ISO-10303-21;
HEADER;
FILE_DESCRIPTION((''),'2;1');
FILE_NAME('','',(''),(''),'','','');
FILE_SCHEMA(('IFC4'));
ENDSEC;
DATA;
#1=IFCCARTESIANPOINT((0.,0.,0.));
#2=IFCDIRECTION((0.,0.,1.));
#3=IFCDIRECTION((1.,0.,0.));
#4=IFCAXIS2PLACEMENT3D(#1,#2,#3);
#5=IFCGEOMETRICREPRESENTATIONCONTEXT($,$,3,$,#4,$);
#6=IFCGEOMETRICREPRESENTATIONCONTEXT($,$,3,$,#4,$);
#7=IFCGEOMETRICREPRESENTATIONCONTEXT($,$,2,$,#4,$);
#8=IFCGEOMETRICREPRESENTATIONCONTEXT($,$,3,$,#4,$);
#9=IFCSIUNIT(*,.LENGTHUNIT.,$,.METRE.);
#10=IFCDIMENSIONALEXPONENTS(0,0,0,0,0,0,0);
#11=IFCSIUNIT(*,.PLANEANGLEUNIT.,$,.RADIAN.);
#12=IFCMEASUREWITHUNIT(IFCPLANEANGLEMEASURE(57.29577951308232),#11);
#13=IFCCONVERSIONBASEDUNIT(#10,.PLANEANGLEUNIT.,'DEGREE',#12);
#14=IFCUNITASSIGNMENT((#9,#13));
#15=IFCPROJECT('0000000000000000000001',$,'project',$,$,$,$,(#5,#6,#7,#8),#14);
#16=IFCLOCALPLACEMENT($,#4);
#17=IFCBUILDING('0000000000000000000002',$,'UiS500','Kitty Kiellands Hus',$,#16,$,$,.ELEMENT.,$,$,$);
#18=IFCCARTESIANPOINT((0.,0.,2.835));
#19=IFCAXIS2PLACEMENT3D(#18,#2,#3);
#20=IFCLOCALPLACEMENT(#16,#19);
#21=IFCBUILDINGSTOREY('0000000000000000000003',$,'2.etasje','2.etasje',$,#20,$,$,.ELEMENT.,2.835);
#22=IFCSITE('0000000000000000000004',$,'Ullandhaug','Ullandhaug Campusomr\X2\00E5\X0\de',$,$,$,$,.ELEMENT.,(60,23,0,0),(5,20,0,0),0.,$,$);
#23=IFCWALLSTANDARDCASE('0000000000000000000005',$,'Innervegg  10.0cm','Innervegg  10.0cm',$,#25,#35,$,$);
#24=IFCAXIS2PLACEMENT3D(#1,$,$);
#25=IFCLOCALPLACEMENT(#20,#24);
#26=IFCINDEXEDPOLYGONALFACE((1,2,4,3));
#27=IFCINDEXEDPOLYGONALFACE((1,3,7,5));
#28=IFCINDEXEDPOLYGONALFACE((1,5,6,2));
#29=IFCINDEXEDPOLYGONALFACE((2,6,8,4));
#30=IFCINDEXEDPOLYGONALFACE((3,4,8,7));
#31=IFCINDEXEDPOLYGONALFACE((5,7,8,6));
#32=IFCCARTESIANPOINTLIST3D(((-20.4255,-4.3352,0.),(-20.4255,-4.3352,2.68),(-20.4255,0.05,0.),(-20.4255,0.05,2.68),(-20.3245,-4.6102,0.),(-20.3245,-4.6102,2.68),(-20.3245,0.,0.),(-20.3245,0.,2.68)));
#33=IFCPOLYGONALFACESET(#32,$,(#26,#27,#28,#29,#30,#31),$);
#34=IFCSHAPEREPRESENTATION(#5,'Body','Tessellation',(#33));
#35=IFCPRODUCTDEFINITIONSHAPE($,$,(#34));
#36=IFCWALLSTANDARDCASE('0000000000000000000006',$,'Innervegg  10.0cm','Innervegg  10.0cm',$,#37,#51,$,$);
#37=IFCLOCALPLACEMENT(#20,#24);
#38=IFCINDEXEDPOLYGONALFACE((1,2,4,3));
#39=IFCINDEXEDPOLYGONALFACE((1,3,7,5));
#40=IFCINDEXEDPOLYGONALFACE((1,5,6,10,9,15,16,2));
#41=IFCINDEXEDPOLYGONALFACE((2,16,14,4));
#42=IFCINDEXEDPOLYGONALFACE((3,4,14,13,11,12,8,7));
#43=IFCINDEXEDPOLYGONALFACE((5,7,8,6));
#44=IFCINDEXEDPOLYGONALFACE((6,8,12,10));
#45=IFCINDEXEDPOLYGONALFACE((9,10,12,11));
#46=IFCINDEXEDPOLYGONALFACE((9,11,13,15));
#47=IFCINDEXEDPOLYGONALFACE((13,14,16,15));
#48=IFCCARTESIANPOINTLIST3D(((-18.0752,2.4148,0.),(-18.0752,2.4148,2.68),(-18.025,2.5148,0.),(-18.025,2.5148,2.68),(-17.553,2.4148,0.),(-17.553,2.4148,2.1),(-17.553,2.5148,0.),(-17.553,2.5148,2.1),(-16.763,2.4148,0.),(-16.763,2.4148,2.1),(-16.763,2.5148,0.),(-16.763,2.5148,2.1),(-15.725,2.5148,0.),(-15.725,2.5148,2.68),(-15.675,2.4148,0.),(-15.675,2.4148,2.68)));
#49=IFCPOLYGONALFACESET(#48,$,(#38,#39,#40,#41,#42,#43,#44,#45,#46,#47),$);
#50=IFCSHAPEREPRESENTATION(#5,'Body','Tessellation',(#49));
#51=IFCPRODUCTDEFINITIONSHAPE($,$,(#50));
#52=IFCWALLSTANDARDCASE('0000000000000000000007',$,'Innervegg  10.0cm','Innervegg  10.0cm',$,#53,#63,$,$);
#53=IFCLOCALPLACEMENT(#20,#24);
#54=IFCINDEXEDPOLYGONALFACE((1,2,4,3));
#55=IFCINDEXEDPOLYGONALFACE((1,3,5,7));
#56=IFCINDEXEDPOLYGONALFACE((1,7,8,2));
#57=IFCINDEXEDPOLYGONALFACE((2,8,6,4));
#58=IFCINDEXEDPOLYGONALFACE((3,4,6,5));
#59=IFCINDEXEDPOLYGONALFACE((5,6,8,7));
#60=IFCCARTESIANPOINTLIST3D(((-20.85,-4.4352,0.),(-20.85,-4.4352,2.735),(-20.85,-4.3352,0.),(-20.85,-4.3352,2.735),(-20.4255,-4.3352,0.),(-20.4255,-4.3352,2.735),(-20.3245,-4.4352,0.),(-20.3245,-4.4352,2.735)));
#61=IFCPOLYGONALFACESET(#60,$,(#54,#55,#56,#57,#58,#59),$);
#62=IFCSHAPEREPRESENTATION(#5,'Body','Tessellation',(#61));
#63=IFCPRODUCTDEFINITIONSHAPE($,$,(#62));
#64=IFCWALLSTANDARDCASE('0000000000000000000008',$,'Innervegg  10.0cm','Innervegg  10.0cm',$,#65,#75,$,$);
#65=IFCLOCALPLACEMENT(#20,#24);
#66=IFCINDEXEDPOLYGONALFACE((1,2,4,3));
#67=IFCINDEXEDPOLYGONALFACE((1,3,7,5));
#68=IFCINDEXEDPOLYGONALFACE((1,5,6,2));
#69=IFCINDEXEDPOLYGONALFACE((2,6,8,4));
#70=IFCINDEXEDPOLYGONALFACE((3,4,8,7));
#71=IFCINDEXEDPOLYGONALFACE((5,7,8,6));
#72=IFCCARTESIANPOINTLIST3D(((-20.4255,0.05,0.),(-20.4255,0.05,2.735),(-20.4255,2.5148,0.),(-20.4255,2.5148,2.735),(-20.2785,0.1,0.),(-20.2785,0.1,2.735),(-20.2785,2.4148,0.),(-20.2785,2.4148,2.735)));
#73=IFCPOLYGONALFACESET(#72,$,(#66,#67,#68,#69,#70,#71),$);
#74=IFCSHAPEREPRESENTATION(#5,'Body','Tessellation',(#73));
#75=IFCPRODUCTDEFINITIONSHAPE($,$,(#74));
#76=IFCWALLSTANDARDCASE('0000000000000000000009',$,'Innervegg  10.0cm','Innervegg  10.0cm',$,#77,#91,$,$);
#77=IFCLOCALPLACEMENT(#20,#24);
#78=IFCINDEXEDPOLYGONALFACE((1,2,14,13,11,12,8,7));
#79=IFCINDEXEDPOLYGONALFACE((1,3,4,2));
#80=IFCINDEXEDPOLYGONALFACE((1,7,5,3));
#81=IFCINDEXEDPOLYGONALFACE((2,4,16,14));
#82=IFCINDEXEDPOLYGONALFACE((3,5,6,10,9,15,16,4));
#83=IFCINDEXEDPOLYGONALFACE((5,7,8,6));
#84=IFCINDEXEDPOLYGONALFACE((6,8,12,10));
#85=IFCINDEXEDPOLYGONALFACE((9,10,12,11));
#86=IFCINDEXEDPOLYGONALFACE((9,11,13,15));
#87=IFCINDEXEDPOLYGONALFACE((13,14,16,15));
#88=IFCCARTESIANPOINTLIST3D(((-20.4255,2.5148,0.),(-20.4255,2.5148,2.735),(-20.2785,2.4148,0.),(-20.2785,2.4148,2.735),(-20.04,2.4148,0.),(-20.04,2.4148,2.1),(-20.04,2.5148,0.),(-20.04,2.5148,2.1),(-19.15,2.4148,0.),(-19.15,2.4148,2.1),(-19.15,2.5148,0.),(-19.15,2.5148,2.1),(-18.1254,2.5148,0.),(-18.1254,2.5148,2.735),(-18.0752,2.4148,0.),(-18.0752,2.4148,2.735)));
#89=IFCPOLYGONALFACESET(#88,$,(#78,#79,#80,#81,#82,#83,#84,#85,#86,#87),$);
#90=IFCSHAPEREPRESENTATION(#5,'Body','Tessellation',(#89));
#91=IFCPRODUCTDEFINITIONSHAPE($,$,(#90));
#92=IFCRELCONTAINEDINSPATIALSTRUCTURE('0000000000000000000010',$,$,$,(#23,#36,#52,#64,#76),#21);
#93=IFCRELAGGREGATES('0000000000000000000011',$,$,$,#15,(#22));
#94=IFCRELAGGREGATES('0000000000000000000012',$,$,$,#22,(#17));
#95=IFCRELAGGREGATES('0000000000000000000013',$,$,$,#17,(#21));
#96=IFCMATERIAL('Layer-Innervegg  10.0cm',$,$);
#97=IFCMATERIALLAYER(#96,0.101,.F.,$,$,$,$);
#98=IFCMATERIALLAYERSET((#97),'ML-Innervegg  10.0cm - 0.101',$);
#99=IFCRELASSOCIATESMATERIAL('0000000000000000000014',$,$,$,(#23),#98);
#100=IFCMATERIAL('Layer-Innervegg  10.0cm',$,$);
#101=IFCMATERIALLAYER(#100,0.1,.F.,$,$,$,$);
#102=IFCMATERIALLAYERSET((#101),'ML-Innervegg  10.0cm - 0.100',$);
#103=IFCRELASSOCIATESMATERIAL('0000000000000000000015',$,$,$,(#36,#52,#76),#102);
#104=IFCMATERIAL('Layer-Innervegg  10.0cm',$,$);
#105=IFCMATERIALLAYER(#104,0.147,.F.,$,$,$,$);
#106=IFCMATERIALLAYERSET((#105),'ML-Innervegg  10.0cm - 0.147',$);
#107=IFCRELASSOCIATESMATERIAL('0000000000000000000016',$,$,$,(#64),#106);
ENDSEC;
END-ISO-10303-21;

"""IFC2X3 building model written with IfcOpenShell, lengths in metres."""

from ifc_helpers import new_model, entity, si_unit, converted_unit, frame, origin_with_axes, place, context, project, spatial, polyline, outline, extrude, material, layer, layer_set, layer_usage, element, save


model = new_model("IFC2X3")

# Units and contexts
context_of_model_1 = context(None, 3, world=origin_with_axes())
context_of_model_2 = context(None, 3, world=origin_with_axes())
context_of_model_3 = context(None, 2, world=origin_with_axes())
context_of_model_4 = context(None, 3, world=origin_with_axes())
ifc_project = project(units=[si_unit("LENGTHUNIT", "METRE"), converted_unit("PLANEANGLEUNIT", "DEGREE", entity("IfcPlaneAngleMeasure", 57.29577951308232), si_unit("PLANEANGLEUNIT", "RADIAN"), dimensions=[0, 0, 0, 0, 0, 0, 0])], contexts=[context_of_model_1, context_of_model_2, context_of_model_3, context_of_model_4])

# Site, building, storey
site = spatial("IfcSite", under=ifc_project, Name="Ullandhaug", Description="Ullandhaug Campusområde", CompositionType="ELEMENT", RefLatitude=(60, 23, 0, 0), RefLongitude=(5, 20, 0, 0), RefElevation=0.0)
building_placement = place(None, origin_with_axes())
building = spatial("IfcBuilding", under=site, at=building_placement, Name="UiS500", Description="Kitty Kiellands Hus", CompositionType="ELEMENT")
storey_placement = place(building_placement, frame((0.0, 0.0, 2.835), z_axis=(0.0, 0.0, 1.0), x_axis=(1.0, 0.0, 0.0)))
storey = spatial("IfcBuildingStorey", under=building, at=storey_placement, Name="2.etasje", Description="2.etasje", CompositionType="ELEMENT", Elevation=2.835)

# Shared definitions
ifc_material_1 = material(Name="Layer-Innervegg  10.0cm")
ifc_layer_1 = layer(ifc_material_1, 0.1, ventilated=False)
ifc_layer_set_1 = layer_set([ifc_layer_1], Name="ML-Innervegg  10.0cm - 0.100")
ifc_layer_usage_1 = layer_usage(ifc_layer_set_1, "AXIS2", "POSITIVE", 0.0)

# Wall
ifc_material_2 = material(Name="Layer-Innervegg  10.0cm")
ifc_layer_2 = layer(ifc_material_2, 0.101, ventilated=False)
ifc_layer_set_2 = layer_set([ifc_layer_2], Name="ML-Innervegg  10.0cm - 0.101")
ifc_layer_usage_2 = layer_usage(ifc_layer_set_2, "AXIS2", "POSITIVE", 0.0)
wall_1_placement = place(storey_placement, frame((-20.4255, 0.05, 0.0), z_axis=(0.0, 0.0, 1.0), x_axis=(0.0, -1.0, 0.0)))
element("IfcWallStandardCase", 1, at=wall_1_placement, inside=storey, material=ifc_layer_usage_2, Name="Innervegg  10.0cm", Description="Innervegg  10.0cm", context=context_of_model_1, shape_type="SweptSolid", body=[
    extrude(outline(polyline([(0.0, 0.0), (4.3852, 0.0), (4.6602, 0.101), (0.05, 0.101), (0.0, 0.0)])), frame((0.0, 0.0, 0.0), z_axis=(0.0, 0.0, 1.0), x_axis=(1.0, 0.0, 0.0)), (0.0, 0.0, 1.0), 2.68),
])

# Wall, opening
wall_2_placement = place(storey_placement, frame((-18.0752, 2.4148, 0.0), z_axis=(0.0, 0.0, 1.0), x_axis=(1.0, 0.0, 0.0)))
wall_2 = element("IfcWallStandardCase", 2, at=wall_2_placement, inside=storey, material=ifc_layer_usage_1, Name="Innervegg  10.0cm", Description="Innervegg  10.0cm", context=context_of_model_1, shape_type="SweptSolid", body=[
    extrude(outline(polyline([(0.0, 0.0), (2.4002, 0.0), (2.3502, 0.1), (0.0502, 0.1), (0.0, 0.0)])), origin_with_axes(), (0.0, 0.0, 1.0), 2.68),
])
opening_1_placement = place(wall_2_placement, frame((0.5222, 0.1, 0.0), z_axis=(0.0, 0.0, 1.0), x_axis=(1.0, 0.0, 0.0)))
element("IfcOpeningElement", 3, at=opening_1_placement, cuts=wall_2, context=context_of_model_1, shape_type="SweptSolid", body=[
    extrude(outline(polyline([(0.0, 0.0), (2.1, 0.0), (2.1, 0.79), (0.0, 0.79), (0.0, 0.0)])), frame((0.0, 0.0, 0.0), z_axis=(0.0, 1.0, 0.0), x_axis=(0.0, 0.0, 1.0)), (0.0, 0.0, -1.0), 0.1),
])

# Walls
wall_3_placement = place(storey_placement, frame((-20.85, -4.4352, 0.0), z_axis=(0.0, 0.0, 1.0), x_axis=(1.0, 0.0, 0.0)))
element("IfcWallStandardCase", 4, at=wall_3_placement, inside=storey, material=ifc_layer_usage_1, Name="Innervegg  10.0cm", Description="Innervegg  10.0cm", context=context_of_model_1, shape_type="SweptSolid", body=[
    extrude(outline(polyline([(0.0, 0.0), (0.5255, 0.0), (0.4245, 0.1), (0.0, 0.1), (0.0, 0.0)])), origin_with_axes(), (0.0, 0.0, 1.0), 2.735),
])
ifc_material_3 = material(Name="Layer-Innervegg  10.0cm")
ifc_layer_3 = layer(ifc_material_3, 0.147, ventilated=False)
ifc_layer_set_3 = layer_set([ifc_layer_3], Name="ML-Innervegg  10.0cm - 0.147")
ifc_layer_usage_3 = layer_usage(ifc_layer_set_3, "AXIS2", "POSITIVE", 0.0)
wall_4_placement = place(storey_placement, frame((-20.2785, 0.1, 0.0), z_axis=(0.0, 0.0, 1.0), x_axis=(0.0, 1.0, 0.0)))
element("IfcWallStandardCase", 5, at=wall_4_placement, inside=storey, material=ifc_layer_usage_3, Name="Innervegg  10.0cm", Description="Innervegg  10.0cm", context=context_of_model_1, shape_type="SweptSolid", body=[
    extrude(outline(polyline([(0.0, 0.0), (2.3148, 0.0), (2.4148, 0.147), (-0.05, 0.147), (0.0, 0.0)])), frame((0.0, 0.0, 0.0), z_axis=(0.0, 0.0, 1.0), x_axis=(1.0, 0.0, 0.0)), (0.0, 0.0, 1.0), 2.735),
])

# Wall, opening
wall_5_placement = place(storey_placement, frame((-20.2785, 2.4148, 0.0), z_axis=(0.0, 0.0, 1.0), x_axis=(1.0, 0.0, 0.0)))
wall_5 = element("IfcWallStandardCase", 6, at=wall_5_placement, inside=storey, material=ifc_layer_usage_1, Name="Innervegg  10.0cm", Description="Innervegg  10.0cm", context=context_of_model_1, shape_type="SweptSolid", body=[
    extrude(outline(polyline([(0.0, 0.0), (2.2033, 0.0), (2.1531, 0.1), (-0.147, 0.1), (0.0, 0.0)])), origin_with_axes(), (0.0, 0.0, 1.0), 2.735),
])
opening_2_placement = place(wall_5_placement, frame((0.2385, 0.1, 0.0), z_axis=(0.0, 0.0, 1.0), x_axis=(1.0, 0.0, 0.0)))
element("IfcOpeningElement", 7, at=opening_2_placement, cuts=wall_5, context=context_of_model_1, shape_type="SweptSolid", body=[
    extrude(outline(polyline([(0.0, 0.0), (2.1, 0.0), (2.1, 0.89), (0.0, 0.89), (0.0, 0.0)])), frame((0.0, 0.0, 0.0), z_axis=(0.0, 1.0, 0.0), x_axis=(0.0, 0.0, 1.0)), (0.0, 0.0, -1.0), 0.1),
])

save(model, "model.ifc")
